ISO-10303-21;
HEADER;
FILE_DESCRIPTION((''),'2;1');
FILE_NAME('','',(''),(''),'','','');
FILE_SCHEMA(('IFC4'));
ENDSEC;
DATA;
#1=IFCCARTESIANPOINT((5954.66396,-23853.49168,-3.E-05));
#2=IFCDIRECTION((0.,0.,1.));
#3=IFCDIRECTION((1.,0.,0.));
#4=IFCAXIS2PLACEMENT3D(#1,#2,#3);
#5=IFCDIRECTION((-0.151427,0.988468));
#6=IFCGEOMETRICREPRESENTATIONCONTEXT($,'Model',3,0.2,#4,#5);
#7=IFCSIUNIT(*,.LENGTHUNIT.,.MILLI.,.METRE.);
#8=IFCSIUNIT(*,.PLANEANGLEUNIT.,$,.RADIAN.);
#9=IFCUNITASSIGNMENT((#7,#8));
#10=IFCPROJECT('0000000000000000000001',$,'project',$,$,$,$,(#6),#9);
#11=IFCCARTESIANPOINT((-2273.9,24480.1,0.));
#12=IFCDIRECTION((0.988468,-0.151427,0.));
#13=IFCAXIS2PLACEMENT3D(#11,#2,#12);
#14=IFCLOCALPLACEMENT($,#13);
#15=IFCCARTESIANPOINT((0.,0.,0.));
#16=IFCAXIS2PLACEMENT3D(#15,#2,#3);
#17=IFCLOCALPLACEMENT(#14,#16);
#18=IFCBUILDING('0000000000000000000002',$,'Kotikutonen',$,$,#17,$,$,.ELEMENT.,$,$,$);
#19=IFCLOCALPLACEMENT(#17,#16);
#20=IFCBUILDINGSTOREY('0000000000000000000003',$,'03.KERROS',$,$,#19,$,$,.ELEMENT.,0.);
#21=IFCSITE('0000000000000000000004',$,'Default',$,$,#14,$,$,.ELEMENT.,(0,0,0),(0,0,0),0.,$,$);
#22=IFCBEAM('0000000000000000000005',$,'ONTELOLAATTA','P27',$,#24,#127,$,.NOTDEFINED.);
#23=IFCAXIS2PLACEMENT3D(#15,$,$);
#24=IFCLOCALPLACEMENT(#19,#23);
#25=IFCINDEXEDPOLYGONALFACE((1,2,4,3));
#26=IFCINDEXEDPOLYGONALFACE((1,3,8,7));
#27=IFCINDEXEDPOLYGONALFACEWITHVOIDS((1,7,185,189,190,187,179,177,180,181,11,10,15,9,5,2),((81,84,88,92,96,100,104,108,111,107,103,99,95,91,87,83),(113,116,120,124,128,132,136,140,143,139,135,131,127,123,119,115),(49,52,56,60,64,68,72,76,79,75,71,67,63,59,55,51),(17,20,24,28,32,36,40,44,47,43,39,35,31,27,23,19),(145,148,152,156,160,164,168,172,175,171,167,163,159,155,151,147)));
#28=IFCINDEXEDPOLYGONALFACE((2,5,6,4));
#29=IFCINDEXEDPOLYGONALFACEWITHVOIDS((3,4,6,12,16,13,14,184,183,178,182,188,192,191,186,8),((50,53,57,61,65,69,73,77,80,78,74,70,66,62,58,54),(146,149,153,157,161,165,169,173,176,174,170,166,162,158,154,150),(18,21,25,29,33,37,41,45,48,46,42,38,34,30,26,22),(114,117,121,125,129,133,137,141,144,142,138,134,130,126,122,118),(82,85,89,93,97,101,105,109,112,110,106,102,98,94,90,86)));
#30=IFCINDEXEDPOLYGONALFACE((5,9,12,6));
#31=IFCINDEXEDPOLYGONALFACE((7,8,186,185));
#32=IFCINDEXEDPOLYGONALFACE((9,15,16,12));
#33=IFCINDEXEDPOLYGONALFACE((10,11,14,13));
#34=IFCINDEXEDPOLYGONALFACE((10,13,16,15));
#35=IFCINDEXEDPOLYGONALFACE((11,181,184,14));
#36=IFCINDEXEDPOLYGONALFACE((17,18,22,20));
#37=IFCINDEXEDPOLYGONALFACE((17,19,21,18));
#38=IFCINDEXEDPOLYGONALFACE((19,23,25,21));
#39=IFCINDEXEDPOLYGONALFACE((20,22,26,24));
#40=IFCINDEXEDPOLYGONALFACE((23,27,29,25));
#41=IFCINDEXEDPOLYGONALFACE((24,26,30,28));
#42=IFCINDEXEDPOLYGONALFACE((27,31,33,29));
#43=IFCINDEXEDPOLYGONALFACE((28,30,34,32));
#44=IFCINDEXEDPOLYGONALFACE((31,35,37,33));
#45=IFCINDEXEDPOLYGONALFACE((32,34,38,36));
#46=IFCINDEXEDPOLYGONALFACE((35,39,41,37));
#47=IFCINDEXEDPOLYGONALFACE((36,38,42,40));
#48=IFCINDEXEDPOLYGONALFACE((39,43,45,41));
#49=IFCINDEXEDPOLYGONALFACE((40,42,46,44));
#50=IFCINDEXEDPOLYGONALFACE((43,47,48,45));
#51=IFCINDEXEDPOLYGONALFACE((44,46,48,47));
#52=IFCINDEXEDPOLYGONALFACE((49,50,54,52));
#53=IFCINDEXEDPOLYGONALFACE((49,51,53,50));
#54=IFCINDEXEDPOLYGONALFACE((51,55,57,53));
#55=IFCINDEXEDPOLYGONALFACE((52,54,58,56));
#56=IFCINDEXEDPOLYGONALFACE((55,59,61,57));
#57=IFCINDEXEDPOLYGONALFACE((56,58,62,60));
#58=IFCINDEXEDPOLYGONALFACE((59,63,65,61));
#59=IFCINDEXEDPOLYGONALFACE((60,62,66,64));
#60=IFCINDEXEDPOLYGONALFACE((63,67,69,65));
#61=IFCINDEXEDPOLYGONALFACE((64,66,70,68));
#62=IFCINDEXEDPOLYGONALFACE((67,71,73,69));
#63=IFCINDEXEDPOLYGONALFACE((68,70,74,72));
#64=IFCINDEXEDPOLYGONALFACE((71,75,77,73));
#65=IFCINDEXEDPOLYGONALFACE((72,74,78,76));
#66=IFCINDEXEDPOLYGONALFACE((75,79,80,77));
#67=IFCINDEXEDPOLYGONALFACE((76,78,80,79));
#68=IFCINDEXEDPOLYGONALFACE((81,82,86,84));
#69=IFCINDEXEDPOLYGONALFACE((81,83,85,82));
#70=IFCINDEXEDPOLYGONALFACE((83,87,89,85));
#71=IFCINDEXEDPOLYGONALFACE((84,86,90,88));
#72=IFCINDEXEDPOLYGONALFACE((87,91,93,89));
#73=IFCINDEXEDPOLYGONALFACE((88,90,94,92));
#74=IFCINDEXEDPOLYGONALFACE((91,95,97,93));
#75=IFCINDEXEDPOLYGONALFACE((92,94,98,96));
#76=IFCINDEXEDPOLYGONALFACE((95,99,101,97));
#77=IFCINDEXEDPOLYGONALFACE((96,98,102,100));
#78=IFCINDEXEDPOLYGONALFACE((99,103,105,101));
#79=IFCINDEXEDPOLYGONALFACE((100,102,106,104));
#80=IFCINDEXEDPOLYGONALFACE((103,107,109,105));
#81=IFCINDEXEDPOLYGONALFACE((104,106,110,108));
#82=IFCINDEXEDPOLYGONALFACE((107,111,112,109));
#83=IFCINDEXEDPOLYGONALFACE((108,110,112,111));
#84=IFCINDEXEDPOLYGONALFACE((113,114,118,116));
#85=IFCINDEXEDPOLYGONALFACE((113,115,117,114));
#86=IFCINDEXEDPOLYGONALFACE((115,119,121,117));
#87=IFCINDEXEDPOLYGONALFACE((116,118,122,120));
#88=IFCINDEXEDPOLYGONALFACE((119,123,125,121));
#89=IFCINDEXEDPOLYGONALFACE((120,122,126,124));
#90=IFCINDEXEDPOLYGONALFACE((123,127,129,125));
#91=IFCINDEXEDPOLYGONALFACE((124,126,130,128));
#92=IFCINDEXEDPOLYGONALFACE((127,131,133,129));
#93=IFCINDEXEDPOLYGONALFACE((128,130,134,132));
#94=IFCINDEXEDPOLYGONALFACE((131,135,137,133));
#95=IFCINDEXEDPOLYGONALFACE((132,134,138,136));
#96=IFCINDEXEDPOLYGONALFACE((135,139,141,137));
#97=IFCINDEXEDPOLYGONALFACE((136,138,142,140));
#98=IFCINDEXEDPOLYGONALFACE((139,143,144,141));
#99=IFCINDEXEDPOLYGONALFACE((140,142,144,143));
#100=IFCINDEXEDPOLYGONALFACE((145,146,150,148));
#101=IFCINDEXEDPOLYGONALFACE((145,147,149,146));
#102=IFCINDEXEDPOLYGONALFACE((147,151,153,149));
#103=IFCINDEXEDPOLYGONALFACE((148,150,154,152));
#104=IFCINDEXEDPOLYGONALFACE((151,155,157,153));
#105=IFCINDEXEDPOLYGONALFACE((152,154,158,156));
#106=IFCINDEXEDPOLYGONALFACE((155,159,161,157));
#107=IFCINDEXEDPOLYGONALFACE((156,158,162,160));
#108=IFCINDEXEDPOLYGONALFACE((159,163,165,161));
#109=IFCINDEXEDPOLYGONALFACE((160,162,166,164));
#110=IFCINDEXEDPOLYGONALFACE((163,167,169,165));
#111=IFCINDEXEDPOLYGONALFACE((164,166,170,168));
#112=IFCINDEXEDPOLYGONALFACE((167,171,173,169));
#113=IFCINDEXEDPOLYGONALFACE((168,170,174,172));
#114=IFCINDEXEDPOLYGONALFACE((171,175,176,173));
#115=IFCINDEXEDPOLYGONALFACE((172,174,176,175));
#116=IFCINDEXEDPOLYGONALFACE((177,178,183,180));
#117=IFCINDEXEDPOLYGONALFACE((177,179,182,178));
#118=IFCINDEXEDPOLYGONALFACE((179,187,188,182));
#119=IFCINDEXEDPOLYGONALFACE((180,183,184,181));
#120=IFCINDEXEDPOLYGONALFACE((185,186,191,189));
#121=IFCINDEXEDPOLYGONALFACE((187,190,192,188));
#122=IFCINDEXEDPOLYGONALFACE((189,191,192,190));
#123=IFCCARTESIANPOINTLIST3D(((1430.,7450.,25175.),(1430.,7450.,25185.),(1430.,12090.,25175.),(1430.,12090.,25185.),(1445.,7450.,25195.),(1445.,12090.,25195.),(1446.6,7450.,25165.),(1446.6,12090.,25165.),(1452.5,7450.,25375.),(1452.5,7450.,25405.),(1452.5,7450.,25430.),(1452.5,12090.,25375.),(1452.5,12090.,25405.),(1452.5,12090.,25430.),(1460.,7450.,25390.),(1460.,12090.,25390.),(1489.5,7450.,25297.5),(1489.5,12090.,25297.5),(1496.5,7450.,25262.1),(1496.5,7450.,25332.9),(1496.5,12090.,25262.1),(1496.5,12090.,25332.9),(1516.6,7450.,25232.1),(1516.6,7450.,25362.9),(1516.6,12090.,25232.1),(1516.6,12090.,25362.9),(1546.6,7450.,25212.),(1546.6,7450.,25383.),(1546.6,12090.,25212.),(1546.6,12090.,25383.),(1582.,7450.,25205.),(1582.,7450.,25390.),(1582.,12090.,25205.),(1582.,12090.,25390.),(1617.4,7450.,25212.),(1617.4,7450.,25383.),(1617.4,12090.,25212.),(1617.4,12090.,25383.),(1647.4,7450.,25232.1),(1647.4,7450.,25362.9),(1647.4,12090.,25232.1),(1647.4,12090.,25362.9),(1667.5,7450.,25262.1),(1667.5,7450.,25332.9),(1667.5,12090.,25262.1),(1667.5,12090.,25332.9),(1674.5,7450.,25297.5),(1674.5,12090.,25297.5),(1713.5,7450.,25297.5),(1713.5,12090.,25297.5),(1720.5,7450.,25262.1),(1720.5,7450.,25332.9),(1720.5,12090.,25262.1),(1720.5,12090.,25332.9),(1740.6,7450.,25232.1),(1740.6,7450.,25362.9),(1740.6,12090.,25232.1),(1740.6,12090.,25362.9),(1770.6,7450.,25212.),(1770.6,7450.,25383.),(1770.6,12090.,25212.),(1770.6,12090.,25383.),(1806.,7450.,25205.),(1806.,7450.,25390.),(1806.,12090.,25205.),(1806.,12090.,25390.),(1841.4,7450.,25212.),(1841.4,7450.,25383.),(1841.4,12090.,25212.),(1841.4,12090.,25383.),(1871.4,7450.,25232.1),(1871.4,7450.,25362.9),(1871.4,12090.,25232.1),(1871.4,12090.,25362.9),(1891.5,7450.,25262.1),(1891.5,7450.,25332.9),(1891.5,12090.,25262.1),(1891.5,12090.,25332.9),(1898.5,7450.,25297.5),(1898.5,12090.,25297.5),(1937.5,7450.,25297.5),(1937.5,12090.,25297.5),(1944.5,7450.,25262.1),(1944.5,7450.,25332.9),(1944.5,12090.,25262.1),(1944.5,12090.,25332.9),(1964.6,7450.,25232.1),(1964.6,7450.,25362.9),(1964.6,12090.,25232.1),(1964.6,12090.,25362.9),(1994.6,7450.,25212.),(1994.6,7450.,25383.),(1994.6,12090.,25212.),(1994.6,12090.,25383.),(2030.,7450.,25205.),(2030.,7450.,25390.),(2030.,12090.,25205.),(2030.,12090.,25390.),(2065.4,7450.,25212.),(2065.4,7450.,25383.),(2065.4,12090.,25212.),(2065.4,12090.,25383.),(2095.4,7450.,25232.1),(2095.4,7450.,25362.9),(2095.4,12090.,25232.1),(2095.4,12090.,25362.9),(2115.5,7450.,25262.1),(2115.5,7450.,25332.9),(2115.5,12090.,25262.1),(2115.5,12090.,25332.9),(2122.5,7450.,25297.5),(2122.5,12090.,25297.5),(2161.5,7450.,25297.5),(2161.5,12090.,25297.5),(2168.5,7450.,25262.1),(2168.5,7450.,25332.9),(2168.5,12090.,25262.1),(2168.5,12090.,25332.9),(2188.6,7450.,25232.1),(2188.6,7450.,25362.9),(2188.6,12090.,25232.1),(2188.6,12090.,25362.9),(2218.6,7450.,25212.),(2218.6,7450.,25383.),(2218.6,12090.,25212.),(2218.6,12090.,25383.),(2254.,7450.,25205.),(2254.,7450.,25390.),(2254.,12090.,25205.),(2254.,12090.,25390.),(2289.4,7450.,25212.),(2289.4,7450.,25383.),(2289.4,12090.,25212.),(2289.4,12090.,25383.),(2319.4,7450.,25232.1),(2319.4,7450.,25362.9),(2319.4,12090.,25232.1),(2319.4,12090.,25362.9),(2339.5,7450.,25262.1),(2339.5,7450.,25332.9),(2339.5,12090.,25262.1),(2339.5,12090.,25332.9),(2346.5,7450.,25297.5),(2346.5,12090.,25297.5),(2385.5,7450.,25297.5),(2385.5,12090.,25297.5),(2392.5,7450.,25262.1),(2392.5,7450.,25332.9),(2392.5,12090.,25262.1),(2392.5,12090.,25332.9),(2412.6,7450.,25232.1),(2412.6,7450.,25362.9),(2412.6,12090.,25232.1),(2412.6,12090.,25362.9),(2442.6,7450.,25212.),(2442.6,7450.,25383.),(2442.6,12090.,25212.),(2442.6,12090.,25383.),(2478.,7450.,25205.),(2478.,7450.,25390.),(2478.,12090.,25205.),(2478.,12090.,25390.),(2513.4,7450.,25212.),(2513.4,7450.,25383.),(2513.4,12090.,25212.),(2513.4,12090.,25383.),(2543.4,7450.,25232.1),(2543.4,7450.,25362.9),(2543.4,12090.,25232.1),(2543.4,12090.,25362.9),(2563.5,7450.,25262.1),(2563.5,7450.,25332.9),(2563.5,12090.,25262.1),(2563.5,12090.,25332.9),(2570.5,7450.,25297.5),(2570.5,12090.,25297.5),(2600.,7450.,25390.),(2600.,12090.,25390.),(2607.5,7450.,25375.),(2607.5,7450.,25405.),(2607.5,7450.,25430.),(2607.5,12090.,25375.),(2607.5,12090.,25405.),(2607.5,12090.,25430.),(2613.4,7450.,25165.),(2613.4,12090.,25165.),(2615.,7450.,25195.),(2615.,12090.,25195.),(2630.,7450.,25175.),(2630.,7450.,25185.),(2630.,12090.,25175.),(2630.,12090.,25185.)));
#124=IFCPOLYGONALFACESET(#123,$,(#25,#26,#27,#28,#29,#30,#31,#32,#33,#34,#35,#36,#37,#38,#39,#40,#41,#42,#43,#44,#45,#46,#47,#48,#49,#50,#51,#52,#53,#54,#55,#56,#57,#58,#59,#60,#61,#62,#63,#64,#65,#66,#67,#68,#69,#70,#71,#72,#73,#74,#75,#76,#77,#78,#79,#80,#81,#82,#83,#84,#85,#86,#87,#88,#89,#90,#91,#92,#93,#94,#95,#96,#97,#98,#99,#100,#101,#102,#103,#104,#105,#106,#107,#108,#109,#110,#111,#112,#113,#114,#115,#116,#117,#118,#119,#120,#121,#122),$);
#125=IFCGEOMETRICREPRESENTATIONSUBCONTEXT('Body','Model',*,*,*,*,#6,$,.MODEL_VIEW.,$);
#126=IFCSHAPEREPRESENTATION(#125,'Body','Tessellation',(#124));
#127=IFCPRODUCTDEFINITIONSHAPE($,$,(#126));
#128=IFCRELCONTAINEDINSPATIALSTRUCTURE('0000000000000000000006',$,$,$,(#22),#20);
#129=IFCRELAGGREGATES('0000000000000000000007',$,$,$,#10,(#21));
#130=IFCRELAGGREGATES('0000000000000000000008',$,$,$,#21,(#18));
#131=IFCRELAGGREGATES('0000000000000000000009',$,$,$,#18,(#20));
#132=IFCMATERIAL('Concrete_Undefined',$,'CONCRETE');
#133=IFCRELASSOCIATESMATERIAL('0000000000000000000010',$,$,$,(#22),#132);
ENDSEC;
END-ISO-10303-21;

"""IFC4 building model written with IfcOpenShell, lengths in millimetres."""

from ifc_helpers import new_model, si_unit, direction, frame, origin_with_axes, place, context, subcontext, project, spatial, line, indexed_curve, outline, extrude, material, element, save


model = new_model("IFC4")

# Units and contexts
model_context = context("Model", 3, precision=0.2, world=frame((5954.66396, -23853.49168, -3e-05), z_axis=(0.0, 0.0, 1.0), x_axis=(1.0, 0.0, 0.0)), true_north=direction((-0.151427, 0.988468)))
body_context = subcontext(model_context, "Body", "Model", "MODEL_VIEW")
ifc_project = project(units=[si_unit("LENGTHUNIT", "METRE", prefix="MILLI"), si_unit("PLANEANGLEUNIT", "RADIAN")], contexts=[model_context])

# Site, building, storey
site_placement = place(None, frame((-2273.9, 24480.1, 0.0), z_axis=(0.0, 0.0, 1.0), x_axis=(0.988468, -0.151427, 0.0)))
site = spatial("IfcSite", under=ifc_project, at=site_placement, Name="Default", CompositionType="ELEMENT", RefLatitude=(0, 0, 0), RefLongitude=(0, 0, 0), RefElevation=0.0)
building_placement = place(site_placement, origin_with_axes())
building = spatial("IfcBuilding", under=site, at=building_placement, Name="Kotikutonen", CompositionType="ELEMENT")
storey_placement = place(building_placement, origin_with_axes())
storey = spatial("IfcBuildingStorey", under=building, at=storey_placement, Name="03.KERROS", CompositionType="ELEMENT", Elevation=0.0)

# Shared definitions
ifc_material_1 = material(Name="Concrete_Undefined", Category="CONCRETE")

# Beam
beam_1_placement = place(storey_placement, frame((2030.0, 12090.0, 25297.5), z_axis=(-1.0, 0.0, 0.0), x_axis=(0.0, -1.0, 0.0)))
element("IfcBeam", 1, at=beam_1_placement, inside=storey, material=ifc_material_1, Name="ONTELOLAATTA", Description="P27", PredefinedType="NOTDEFINED", context=body_context, shape_type="SolidModel", body=[
    extrude(outline(indexed_curve([(-600.0, -122.5), (-583.4, -132.5), (583.4, -132.5), (600.0, -122.5), (600.0, -112.5), (585.0, -102.5), (577.5, 77.5), (570.0, 92.5), (577.5, 107.5), (577.5, 132.5), (-577.5, 132.5), (-577.5, 107.5), (-570.0, 92.5), (-577.5, 77.5), (-585.0, -102.5), (-600.0, -112.5)], segments=[line(1, 2, 3, 4, 5, 6, 7, 8, 9, 10, 11, 12, 13, 14, 15, 16, 1)]), holes=[indexed_curve([(-448.0, -92.5), (-483.4, -85.5), (-513.4, -65.4), (-533.5, -35.4), (-540.5, 0.0), (-533.5, 35.4), (-513.4, 65.4), (-483.4, 85.5), (-448.0, 92.5), (-412.6, 85.5), (-382.6, 65.4), (-362.5, 35.4), (-355.5, 0.0), (-362.5, -35.4), (-382.6, -65.4), (-412.6, -85.5)], segments=[line(1, 2, 3, 4, 5, 6, 7, 8, 9, 10, 11, 12, 13, 14, 15, 16, 1)]), indexed_curve([(-224.0, -92.5), (-259.4, -85.5), (-289.4, -65.4), (-309.5, -35.4), (-316.5, 0.0), (-309.5, 35.4), (-289.4, 65.4), (-259.4, 85.5), (-224.0, 92.5), (-188.6, 85.5), (-158.6, 65.4), (-138.5, 35.4), (-131.5, 0.0), (-138.5, -35.4), (-158.6, -65.4), (-188.6, -85.5)], segments=[line(1, 2, 3, 4, 5, 6, 7, 8, 9, 10, 11, 12, 13, 14, 15, 16, 1)]), indexed_curve([(0.0, -92.5), (-35.4, -85.5), (-65.4, -65.4), (-85.5, -35.4), (-92.5, 0.0), (-85.5, 35.4), (-65.4, 65.4), (-35.4, 85.5), (0.0, 92.5), (35.4, 85.5), (65.4, 65.4), (85.5, 35.4), (92.5, 0.0), (85.5, -35.4), (65.4, -65.4), (35.4, -85.5)], segments=[line(1, 2, 3, 4, 5, 6, 7, 8, 9, 10, 11, 12, 13, 14, 15, 16, 1)]), indexed_curve([(224.0, -92.5), (188.6, -85.5), (158.6, -65.4), (138.5, -35.4), (131.5, 0.0), (138.5, 35.4), (158.6, 65.4), (188.6, 85.5), (224.0, 92.5), (259.4, 85.5), (289.4, 65.4), (309.5, 35.4), (316.5, 0.0), (309.5, -35.4), (289.4, -65.4), (259.4, -85.5)], segments=[line(1, 2, 3, 4, 5, 6, 7, 8, 9, 10, 11, 12, 13, 14, 15, 16, 1)]), indexed_curve([(448.0, -92.5), (412.6, -85.5), (382.6, -65.4), (362.5, -35.4), (355.5, 0.0), (362.5, 35.4), (382.6, 65.4), (412.6, 85.5), (448.0, 92.5), (483.4, 85.5), (513.4, 65.4), (533.5, 35.4), (540.5, 0.0), (533.5, -35.4), (513.4, -65.4), (483.4, -85.5)], segments=[line(1, 2, 3, 4, 5, 6, 7, 8, 9, 10, 11, 12, 13, 14, 15, 16, 1)])]), frame((0.0, 0.0, 0.0), z_axis=(-1.0, 0.0, 0.0), x_axis=(0.0, 0.0, 1.0)), (0.0, 0.0, -1.0), 4640.0),
])

save(model, "model.ifc")
